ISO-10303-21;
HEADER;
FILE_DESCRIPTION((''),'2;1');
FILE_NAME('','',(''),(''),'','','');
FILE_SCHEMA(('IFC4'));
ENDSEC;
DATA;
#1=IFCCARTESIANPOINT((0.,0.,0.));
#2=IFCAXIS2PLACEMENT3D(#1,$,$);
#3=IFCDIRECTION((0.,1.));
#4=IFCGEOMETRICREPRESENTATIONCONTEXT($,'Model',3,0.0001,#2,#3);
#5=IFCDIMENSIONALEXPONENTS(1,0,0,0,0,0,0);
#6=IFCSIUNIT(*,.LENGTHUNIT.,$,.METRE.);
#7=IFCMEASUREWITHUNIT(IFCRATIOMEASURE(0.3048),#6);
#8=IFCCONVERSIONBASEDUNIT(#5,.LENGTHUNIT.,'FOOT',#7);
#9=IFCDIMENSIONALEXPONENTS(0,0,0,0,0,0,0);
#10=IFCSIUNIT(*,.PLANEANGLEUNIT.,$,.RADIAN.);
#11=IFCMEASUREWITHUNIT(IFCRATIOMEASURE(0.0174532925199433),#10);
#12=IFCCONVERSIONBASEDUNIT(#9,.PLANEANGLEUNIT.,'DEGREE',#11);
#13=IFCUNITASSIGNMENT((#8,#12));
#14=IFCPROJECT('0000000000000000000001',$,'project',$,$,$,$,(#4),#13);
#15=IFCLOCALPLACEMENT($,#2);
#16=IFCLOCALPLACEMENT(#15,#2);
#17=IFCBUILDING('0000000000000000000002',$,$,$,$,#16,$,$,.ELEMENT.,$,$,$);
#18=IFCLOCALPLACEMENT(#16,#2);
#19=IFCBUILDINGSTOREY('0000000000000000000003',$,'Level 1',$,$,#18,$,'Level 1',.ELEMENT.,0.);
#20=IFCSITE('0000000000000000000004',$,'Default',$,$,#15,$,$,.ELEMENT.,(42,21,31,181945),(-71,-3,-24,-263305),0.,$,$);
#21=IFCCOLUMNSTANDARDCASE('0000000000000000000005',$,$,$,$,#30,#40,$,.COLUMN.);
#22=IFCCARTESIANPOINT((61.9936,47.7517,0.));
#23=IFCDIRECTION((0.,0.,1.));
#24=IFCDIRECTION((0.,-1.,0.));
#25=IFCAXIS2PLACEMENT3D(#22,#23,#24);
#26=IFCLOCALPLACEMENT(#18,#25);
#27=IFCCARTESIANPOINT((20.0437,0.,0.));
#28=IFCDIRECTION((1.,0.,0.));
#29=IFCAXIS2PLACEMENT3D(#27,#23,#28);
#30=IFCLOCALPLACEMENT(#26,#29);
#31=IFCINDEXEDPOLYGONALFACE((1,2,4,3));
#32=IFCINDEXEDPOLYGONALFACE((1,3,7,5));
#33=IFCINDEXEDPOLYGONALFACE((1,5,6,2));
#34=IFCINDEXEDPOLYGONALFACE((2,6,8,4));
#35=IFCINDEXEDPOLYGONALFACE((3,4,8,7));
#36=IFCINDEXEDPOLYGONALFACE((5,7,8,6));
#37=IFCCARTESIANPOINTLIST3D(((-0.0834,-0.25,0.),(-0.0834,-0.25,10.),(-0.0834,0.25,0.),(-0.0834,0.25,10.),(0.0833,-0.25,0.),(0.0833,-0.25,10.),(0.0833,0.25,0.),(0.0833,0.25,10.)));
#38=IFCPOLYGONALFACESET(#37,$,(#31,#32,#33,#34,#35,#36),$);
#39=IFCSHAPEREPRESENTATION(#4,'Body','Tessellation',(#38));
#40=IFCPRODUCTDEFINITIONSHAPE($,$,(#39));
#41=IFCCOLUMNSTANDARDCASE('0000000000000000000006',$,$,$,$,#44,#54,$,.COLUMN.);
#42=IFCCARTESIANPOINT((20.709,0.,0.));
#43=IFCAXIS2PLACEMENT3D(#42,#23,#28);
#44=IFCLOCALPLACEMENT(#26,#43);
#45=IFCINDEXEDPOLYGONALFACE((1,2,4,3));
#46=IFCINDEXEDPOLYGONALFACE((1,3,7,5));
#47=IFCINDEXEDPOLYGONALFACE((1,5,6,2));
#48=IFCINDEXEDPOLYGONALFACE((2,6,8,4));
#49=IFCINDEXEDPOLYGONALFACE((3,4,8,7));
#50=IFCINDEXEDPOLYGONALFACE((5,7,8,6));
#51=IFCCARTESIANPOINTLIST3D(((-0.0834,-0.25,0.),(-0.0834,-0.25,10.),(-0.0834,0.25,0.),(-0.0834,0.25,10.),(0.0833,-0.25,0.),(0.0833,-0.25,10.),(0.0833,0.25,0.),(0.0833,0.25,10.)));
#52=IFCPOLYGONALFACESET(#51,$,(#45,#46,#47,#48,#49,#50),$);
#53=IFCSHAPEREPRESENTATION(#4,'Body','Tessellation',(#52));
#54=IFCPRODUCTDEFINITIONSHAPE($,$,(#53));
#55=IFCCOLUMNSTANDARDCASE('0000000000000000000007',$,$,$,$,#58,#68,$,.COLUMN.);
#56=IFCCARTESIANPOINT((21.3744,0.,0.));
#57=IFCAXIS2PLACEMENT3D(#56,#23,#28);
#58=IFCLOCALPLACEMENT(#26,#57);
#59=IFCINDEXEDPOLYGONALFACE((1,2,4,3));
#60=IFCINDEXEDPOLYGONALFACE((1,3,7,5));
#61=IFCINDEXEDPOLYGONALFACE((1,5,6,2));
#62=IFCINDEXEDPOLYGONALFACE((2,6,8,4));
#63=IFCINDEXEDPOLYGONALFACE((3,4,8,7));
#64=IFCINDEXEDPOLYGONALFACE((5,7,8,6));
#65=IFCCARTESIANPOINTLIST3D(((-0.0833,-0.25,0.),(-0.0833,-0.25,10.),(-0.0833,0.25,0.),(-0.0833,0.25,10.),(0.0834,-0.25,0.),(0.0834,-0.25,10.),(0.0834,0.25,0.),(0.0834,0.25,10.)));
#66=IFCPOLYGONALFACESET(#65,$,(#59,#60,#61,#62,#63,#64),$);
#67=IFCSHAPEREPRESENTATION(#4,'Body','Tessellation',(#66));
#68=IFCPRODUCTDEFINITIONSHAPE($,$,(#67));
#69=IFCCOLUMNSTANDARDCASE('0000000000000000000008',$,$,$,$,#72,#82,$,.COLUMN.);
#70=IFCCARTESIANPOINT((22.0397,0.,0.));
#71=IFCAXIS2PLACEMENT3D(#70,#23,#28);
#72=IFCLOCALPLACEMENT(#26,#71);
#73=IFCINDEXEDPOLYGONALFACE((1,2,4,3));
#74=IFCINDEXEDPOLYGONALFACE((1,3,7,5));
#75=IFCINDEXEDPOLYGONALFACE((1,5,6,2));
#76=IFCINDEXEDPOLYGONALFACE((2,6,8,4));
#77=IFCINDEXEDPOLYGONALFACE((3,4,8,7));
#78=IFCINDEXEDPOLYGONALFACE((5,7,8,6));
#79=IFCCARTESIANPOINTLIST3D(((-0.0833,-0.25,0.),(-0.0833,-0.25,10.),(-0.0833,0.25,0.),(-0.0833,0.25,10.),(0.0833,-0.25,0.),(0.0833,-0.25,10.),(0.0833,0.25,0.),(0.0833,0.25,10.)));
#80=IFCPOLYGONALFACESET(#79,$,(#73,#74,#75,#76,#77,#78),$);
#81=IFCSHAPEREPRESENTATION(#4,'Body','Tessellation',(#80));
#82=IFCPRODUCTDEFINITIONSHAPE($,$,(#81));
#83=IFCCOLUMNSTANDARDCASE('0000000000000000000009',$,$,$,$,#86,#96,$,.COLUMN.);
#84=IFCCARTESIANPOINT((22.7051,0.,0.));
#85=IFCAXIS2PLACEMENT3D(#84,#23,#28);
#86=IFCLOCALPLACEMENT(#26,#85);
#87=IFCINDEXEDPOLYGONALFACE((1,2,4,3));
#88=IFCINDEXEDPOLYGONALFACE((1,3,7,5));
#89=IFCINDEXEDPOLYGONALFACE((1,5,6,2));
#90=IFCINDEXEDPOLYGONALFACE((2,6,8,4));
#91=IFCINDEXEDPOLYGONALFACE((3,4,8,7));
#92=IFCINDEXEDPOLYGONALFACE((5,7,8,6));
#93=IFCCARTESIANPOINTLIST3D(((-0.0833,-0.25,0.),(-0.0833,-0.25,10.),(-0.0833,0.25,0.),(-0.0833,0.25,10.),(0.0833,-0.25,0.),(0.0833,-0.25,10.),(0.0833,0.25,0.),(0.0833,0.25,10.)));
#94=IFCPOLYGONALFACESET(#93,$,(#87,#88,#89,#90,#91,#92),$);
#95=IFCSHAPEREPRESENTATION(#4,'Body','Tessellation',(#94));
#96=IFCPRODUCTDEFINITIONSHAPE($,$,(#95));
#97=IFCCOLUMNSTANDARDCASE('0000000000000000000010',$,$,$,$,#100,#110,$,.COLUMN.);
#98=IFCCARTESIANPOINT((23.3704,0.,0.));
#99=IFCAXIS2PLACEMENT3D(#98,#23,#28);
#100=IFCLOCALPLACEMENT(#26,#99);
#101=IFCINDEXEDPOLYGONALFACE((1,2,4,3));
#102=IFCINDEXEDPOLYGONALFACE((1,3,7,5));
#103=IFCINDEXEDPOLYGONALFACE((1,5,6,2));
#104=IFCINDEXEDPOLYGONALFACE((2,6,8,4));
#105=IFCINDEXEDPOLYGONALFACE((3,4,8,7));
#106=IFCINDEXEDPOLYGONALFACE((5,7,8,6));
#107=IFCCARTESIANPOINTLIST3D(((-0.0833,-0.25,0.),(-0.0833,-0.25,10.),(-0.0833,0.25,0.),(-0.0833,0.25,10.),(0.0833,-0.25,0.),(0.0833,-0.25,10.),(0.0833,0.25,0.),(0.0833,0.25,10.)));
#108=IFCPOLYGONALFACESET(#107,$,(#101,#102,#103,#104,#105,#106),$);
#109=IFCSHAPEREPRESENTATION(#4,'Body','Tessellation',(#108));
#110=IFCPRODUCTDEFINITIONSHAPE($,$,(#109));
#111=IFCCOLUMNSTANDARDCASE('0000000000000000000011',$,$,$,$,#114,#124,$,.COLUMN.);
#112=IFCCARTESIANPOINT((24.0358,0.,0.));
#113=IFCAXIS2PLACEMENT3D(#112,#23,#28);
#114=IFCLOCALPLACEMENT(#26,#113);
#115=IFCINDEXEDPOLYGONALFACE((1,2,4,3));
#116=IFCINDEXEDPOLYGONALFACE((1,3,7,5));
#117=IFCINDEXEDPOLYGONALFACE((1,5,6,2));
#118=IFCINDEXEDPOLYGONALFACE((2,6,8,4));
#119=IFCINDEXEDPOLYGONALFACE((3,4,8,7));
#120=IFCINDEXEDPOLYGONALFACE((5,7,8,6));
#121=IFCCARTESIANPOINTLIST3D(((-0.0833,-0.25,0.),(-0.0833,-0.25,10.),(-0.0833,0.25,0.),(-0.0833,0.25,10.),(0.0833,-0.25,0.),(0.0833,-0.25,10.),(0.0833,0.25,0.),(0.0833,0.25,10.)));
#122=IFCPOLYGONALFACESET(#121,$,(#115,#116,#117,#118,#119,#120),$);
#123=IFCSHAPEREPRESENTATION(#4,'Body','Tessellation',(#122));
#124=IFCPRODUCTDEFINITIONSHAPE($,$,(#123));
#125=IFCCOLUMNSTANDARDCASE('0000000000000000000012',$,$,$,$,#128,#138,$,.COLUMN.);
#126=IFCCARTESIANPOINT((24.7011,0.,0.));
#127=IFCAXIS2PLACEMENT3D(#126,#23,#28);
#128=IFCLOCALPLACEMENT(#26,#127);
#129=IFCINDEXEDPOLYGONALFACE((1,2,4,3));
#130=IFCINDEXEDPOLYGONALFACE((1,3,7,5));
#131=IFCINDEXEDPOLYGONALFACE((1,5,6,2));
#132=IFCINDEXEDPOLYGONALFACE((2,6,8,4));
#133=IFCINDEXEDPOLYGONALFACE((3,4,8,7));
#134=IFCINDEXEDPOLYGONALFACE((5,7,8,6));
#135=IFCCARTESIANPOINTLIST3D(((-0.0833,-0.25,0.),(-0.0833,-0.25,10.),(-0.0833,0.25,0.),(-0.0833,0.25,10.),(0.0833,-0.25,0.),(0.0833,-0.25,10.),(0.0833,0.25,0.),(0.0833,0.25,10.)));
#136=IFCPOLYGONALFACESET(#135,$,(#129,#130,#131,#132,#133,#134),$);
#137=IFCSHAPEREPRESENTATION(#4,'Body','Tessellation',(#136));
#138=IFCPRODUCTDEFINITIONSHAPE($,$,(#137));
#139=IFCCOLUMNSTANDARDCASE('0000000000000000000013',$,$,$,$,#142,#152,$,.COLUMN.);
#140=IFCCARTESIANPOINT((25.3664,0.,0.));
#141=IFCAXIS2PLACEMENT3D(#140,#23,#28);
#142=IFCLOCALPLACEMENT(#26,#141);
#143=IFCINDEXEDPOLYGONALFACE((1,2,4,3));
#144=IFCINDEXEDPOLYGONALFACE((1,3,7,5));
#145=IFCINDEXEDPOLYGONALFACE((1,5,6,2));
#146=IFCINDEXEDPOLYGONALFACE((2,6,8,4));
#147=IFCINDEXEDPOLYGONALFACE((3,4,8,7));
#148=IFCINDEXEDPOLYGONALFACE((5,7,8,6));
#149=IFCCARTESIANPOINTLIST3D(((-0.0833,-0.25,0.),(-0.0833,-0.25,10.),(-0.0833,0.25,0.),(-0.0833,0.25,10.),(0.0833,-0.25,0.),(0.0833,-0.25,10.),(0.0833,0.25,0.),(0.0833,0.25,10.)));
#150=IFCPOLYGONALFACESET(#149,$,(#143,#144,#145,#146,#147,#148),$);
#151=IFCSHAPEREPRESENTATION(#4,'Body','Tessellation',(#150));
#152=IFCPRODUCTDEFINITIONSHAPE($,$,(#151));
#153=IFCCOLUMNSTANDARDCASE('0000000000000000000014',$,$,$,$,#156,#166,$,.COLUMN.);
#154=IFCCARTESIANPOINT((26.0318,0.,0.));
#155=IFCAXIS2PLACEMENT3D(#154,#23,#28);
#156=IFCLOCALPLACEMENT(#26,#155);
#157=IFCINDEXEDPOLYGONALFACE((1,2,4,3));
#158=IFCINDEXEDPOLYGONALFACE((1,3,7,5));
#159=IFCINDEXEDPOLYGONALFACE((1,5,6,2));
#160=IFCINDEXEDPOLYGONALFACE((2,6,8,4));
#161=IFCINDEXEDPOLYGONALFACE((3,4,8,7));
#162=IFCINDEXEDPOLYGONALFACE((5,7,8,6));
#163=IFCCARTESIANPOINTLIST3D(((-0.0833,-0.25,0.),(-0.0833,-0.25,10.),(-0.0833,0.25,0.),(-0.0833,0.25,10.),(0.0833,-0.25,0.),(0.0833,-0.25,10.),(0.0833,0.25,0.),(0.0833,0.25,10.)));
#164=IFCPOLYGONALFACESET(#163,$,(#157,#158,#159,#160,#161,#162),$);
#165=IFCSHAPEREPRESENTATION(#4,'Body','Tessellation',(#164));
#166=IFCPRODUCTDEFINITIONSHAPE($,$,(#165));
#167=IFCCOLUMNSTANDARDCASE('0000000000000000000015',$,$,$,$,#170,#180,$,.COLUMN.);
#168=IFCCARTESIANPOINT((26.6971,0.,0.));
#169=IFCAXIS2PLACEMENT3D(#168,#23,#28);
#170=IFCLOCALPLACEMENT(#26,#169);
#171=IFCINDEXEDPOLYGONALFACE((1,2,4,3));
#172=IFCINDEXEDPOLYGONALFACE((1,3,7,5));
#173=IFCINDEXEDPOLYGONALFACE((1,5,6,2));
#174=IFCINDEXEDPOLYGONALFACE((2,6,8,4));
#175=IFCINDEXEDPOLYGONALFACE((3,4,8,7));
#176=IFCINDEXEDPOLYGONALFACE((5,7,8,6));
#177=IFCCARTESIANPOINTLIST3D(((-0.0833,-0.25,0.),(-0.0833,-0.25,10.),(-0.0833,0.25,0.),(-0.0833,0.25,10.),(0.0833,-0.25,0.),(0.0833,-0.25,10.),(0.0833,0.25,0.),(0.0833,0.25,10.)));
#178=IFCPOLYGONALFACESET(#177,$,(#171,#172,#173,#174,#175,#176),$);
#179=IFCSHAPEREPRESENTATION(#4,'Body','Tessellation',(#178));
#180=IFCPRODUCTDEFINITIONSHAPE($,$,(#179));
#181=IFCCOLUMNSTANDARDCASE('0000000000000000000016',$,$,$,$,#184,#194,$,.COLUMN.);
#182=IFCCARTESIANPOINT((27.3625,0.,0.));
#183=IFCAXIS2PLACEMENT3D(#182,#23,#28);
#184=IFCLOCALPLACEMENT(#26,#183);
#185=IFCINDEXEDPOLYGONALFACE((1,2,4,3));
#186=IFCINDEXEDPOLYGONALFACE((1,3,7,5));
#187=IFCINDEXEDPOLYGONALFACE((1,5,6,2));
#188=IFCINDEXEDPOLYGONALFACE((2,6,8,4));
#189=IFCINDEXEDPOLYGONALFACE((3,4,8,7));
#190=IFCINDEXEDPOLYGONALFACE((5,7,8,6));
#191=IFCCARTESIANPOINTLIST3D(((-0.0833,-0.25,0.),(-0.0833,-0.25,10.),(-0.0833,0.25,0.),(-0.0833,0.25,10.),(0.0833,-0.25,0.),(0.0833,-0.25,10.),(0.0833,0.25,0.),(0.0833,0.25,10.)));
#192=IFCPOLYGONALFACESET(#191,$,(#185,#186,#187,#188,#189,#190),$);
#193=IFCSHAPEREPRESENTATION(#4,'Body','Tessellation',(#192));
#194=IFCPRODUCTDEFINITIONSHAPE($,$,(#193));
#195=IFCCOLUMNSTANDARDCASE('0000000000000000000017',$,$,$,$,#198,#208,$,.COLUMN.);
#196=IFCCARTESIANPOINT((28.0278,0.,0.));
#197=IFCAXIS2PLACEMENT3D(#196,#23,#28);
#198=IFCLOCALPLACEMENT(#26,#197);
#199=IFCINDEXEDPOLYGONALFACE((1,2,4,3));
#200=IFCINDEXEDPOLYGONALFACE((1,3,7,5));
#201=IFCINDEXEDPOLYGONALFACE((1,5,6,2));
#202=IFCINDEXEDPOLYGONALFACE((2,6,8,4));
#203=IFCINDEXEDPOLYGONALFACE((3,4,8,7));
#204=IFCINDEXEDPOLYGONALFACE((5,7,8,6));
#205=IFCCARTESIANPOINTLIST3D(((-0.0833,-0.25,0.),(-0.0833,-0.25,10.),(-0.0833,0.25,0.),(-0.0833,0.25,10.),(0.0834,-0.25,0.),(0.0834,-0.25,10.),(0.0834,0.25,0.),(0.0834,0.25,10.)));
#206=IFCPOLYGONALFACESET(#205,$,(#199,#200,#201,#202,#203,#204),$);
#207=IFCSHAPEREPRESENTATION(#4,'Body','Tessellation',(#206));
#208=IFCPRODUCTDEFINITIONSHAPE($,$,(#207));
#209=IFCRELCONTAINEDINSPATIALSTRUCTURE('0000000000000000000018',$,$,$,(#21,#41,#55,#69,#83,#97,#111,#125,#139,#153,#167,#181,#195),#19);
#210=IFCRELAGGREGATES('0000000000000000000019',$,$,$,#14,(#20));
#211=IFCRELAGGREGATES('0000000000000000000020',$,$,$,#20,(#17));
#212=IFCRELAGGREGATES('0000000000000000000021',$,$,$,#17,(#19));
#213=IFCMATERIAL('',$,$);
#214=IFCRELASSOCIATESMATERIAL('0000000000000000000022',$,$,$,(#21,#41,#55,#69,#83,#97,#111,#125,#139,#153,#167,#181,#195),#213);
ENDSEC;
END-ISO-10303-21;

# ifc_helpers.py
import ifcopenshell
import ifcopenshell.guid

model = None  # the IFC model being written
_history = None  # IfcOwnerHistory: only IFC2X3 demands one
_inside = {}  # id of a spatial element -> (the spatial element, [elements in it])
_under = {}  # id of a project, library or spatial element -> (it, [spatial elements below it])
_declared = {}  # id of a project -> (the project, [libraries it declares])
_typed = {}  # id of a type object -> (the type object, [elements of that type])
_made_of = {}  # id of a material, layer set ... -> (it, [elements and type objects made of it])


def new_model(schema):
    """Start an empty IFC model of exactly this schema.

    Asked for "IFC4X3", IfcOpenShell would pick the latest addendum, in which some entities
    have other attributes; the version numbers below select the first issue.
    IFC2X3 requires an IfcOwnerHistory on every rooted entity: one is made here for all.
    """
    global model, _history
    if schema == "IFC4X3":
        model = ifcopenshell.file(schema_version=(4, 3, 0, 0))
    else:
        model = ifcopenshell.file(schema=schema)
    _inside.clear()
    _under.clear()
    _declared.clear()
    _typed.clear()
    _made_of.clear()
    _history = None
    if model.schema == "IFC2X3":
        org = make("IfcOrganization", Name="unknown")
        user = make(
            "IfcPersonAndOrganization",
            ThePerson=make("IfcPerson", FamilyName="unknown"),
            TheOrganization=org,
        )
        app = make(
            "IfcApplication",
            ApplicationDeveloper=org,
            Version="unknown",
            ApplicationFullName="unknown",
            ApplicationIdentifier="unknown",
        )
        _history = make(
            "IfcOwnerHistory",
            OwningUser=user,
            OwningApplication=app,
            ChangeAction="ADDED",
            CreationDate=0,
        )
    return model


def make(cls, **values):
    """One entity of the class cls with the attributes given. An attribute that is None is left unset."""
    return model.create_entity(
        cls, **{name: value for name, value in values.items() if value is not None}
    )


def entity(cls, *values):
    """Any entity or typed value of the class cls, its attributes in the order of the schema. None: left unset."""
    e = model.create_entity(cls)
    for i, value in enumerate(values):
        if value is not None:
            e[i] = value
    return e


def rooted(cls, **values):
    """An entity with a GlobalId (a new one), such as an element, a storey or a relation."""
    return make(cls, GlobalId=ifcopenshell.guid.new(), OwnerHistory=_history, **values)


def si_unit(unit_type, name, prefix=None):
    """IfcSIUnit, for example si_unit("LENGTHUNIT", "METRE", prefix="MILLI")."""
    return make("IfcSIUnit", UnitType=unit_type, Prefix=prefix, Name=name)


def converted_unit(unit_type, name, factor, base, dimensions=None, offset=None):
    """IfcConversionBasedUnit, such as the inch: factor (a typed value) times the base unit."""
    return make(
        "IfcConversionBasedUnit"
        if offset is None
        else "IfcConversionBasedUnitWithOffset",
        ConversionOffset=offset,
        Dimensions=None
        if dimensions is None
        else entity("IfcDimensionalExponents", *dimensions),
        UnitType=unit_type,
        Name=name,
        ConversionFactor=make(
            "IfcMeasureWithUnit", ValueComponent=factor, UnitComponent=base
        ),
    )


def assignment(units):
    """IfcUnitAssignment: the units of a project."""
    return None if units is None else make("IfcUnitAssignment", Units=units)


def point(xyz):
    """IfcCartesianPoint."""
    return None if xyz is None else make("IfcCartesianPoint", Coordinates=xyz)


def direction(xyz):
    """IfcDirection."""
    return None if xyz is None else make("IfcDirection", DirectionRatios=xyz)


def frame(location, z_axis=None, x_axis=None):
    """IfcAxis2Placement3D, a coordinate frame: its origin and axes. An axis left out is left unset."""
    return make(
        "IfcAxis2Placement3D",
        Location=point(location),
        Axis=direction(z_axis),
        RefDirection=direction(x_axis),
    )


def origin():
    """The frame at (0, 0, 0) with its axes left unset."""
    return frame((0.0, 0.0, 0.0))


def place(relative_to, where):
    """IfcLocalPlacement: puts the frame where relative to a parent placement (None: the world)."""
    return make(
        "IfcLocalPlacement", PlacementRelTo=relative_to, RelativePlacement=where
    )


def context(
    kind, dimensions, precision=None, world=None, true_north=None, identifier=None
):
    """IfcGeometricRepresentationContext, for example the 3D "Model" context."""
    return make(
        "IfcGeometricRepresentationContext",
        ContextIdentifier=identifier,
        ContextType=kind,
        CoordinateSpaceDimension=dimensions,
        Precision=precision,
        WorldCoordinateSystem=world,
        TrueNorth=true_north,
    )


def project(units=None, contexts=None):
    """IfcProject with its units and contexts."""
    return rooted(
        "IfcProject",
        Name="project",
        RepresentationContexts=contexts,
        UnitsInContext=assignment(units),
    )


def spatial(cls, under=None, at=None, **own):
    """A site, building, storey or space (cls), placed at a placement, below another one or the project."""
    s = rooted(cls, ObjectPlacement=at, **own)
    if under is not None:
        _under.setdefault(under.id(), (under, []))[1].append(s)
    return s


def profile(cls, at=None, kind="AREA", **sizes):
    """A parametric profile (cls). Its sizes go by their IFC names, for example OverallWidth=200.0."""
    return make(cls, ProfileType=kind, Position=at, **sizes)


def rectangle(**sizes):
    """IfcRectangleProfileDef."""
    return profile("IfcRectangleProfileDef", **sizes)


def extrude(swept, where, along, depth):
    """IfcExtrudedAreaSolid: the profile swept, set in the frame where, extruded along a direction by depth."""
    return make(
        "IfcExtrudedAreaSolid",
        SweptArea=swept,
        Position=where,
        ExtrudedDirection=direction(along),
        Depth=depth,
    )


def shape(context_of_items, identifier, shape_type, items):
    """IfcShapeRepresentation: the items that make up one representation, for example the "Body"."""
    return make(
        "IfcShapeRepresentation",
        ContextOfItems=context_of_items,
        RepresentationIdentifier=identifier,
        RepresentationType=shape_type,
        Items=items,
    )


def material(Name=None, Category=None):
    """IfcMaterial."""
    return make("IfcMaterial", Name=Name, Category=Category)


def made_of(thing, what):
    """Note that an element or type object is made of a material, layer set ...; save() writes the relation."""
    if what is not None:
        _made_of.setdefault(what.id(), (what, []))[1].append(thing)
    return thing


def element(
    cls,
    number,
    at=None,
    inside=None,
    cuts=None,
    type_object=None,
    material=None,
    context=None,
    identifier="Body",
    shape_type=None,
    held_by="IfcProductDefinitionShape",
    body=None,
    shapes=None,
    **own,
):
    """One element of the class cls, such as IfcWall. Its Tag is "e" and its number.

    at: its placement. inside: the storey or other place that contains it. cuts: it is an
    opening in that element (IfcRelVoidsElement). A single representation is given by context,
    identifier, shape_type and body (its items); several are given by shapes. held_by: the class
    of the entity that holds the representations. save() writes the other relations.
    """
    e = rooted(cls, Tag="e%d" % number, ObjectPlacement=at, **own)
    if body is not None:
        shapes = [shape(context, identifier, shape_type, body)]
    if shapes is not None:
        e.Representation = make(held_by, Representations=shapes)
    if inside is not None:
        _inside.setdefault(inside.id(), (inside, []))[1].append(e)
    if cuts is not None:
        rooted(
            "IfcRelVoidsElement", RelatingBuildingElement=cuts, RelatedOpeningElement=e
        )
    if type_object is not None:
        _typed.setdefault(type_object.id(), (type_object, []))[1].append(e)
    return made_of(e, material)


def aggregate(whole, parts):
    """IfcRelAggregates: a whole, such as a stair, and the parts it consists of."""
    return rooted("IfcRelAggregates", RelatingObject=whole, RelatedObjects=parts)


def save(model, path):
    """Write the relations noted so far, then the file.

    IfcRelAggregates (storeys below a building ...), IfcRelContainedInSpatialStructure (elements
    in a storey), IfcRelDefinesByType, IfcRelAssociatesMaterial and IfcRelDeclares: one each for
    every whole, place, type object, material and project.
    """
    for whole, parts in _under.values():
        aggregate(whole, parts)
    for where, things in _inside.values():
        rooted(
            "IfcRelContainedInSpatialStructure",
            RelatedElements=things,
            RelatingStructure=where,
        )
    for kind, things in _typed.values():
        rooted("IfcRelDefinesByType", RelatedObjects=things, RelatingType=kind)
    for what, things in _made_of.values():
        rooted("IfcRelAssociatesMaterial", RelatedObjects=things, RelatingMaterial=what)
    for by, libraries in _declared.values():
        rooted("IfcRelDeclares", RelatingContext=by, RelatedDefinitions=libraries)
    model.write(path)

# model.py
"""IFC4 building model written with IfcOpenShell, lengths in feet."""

from ifc_helpers import new_model, entity, si_unit, converted_unit, direction, frame, origin, place, context, project, spatial, rectangle, extrude, material, element, save


model = new_model("IFC4")

# Units and contexts
model_context = context("Model", 3, precision=0.0001, world=origin(), true_north=direction((0.0, 1.0)))
ifc_project = project(units=[converted_unit("LENGTHUNIT", "FOOT", entity("IfcRatioMeasure", 0.3048), si_unit("LENGTHUNIT", "METRE"), dimensions=[1, 0, 0, 0, 0, 0, 0]), converted_unit("PLANEANGLEUNIT", "DEGREE", entity("IfcRatioMeasure", 0.0174532925199433), si_unit("PLANEANGLEUNIT", "RADIAN"), dimensions=[0, 0, 0, 0, 0, 0, 0])], contexts=[model_context])

# Site, building, storey
site_placement = place(None, origin())
site = spatial("IfcSite", under=ifc_project, at=site_placement, Name="Default", CompositionType="ELEMENT", RefLatitude=(42, 21, 31, 181945), RefLongitude=(-71, -3, -24, -263305), RefElevation=0.0)
building_placement = place(site_placement, origin())
building = spatial("IfcBuilding", under=site, at=building_placement, CompositionType="ELEMENT")
storey_placement = place(building_placement, origin())
storey = spatial("IfcBuildingStorey", under=building, at=storey_placement, Name="Level 1", LongName="Level 1", CompositionType="ELEMENT", Elevation=0.0)

# Columns
ifc_material_1 = material(Name="")
placement = place(storey_placement, frame((61.9936, 47.7517, 0.0), z_axis=(0.0, 0.0, 1.0), x_axis=(0.0, -1.0, 0.0)))
for number, where, z_axis, x_axis in (
    (1, (20.0437, 0.0, 0.0), (0.0, 0.0, 1.0), (1.0, 0.0, 0.0)),
    (2, (20.709, 0.0, 0.0), (0.0, 0.0, 1.0), (1.0, 0.0, 0.0)),
    (3, (21.3744, 0.0, 0.0), (0.0, 0.0, 1.0), (1.0, 0.0, 0.0)),
    (4, (22.0397, 0.0, 0.0), (0.0, 0.0, 1.0), (1.0, 0.0, 0.0)),
    (5, (22.7051, 0.0, 0.0), (0.0, 0.0, 1.0), (1.0, 0.0, 0.0)),
    (6, (23.3704, 0.0, 0.0), (0.0, 0.0, 1.0), (1.0, 0.0, 0.0)),
    (7, (24.0358, 0.0, 0.0), (0.0, 0.0, 1.0), (1.0, 0.0, 0.0)),
    (8, (24.7011, 0.0, 0.0), (0.0, 0.0, 1.0), (1.0, 0.0, 0.0)),
    (9, (25.3664, 0.0, 0.0), (0.0, 0.0, 1.0), (1.0, 0.0, 0.0)),
    (10, (26.0318, 0.0, 0.0), (0.0, 0.0, 1.0), (1.0, 0.0, 0.0)),
    (11, (26.6971, 0.0, 0.0), (0.0, 0.0, 1.0), (1.0, 0.0, 0.0)),
    (12, (27.3625, 0.0, 0.0), (0.0, 0.0, 1.0), (1.0, 0.0, 0.0)),
    (13, (28.0278, 0.0, 0.0), (0.0, 0.0, 1.0), (1.0, 0.0, 0.0)),
):
    element("IfcColumnStandardCase", number, at=place(placement, frame(where, z_axis=z_axis, x_axis=x_axis)), inside=storey, material=ifc_material_1, PredefinedType="COLUMN", context=model_context, shape_type="SweptSolid", body=[
        extrude(rectangle(XDim=0.1667, YDim=0.5), origin(), (0.0, 0.0, 1.0), 10.0),
    ])

save(model, "model.ifc")
